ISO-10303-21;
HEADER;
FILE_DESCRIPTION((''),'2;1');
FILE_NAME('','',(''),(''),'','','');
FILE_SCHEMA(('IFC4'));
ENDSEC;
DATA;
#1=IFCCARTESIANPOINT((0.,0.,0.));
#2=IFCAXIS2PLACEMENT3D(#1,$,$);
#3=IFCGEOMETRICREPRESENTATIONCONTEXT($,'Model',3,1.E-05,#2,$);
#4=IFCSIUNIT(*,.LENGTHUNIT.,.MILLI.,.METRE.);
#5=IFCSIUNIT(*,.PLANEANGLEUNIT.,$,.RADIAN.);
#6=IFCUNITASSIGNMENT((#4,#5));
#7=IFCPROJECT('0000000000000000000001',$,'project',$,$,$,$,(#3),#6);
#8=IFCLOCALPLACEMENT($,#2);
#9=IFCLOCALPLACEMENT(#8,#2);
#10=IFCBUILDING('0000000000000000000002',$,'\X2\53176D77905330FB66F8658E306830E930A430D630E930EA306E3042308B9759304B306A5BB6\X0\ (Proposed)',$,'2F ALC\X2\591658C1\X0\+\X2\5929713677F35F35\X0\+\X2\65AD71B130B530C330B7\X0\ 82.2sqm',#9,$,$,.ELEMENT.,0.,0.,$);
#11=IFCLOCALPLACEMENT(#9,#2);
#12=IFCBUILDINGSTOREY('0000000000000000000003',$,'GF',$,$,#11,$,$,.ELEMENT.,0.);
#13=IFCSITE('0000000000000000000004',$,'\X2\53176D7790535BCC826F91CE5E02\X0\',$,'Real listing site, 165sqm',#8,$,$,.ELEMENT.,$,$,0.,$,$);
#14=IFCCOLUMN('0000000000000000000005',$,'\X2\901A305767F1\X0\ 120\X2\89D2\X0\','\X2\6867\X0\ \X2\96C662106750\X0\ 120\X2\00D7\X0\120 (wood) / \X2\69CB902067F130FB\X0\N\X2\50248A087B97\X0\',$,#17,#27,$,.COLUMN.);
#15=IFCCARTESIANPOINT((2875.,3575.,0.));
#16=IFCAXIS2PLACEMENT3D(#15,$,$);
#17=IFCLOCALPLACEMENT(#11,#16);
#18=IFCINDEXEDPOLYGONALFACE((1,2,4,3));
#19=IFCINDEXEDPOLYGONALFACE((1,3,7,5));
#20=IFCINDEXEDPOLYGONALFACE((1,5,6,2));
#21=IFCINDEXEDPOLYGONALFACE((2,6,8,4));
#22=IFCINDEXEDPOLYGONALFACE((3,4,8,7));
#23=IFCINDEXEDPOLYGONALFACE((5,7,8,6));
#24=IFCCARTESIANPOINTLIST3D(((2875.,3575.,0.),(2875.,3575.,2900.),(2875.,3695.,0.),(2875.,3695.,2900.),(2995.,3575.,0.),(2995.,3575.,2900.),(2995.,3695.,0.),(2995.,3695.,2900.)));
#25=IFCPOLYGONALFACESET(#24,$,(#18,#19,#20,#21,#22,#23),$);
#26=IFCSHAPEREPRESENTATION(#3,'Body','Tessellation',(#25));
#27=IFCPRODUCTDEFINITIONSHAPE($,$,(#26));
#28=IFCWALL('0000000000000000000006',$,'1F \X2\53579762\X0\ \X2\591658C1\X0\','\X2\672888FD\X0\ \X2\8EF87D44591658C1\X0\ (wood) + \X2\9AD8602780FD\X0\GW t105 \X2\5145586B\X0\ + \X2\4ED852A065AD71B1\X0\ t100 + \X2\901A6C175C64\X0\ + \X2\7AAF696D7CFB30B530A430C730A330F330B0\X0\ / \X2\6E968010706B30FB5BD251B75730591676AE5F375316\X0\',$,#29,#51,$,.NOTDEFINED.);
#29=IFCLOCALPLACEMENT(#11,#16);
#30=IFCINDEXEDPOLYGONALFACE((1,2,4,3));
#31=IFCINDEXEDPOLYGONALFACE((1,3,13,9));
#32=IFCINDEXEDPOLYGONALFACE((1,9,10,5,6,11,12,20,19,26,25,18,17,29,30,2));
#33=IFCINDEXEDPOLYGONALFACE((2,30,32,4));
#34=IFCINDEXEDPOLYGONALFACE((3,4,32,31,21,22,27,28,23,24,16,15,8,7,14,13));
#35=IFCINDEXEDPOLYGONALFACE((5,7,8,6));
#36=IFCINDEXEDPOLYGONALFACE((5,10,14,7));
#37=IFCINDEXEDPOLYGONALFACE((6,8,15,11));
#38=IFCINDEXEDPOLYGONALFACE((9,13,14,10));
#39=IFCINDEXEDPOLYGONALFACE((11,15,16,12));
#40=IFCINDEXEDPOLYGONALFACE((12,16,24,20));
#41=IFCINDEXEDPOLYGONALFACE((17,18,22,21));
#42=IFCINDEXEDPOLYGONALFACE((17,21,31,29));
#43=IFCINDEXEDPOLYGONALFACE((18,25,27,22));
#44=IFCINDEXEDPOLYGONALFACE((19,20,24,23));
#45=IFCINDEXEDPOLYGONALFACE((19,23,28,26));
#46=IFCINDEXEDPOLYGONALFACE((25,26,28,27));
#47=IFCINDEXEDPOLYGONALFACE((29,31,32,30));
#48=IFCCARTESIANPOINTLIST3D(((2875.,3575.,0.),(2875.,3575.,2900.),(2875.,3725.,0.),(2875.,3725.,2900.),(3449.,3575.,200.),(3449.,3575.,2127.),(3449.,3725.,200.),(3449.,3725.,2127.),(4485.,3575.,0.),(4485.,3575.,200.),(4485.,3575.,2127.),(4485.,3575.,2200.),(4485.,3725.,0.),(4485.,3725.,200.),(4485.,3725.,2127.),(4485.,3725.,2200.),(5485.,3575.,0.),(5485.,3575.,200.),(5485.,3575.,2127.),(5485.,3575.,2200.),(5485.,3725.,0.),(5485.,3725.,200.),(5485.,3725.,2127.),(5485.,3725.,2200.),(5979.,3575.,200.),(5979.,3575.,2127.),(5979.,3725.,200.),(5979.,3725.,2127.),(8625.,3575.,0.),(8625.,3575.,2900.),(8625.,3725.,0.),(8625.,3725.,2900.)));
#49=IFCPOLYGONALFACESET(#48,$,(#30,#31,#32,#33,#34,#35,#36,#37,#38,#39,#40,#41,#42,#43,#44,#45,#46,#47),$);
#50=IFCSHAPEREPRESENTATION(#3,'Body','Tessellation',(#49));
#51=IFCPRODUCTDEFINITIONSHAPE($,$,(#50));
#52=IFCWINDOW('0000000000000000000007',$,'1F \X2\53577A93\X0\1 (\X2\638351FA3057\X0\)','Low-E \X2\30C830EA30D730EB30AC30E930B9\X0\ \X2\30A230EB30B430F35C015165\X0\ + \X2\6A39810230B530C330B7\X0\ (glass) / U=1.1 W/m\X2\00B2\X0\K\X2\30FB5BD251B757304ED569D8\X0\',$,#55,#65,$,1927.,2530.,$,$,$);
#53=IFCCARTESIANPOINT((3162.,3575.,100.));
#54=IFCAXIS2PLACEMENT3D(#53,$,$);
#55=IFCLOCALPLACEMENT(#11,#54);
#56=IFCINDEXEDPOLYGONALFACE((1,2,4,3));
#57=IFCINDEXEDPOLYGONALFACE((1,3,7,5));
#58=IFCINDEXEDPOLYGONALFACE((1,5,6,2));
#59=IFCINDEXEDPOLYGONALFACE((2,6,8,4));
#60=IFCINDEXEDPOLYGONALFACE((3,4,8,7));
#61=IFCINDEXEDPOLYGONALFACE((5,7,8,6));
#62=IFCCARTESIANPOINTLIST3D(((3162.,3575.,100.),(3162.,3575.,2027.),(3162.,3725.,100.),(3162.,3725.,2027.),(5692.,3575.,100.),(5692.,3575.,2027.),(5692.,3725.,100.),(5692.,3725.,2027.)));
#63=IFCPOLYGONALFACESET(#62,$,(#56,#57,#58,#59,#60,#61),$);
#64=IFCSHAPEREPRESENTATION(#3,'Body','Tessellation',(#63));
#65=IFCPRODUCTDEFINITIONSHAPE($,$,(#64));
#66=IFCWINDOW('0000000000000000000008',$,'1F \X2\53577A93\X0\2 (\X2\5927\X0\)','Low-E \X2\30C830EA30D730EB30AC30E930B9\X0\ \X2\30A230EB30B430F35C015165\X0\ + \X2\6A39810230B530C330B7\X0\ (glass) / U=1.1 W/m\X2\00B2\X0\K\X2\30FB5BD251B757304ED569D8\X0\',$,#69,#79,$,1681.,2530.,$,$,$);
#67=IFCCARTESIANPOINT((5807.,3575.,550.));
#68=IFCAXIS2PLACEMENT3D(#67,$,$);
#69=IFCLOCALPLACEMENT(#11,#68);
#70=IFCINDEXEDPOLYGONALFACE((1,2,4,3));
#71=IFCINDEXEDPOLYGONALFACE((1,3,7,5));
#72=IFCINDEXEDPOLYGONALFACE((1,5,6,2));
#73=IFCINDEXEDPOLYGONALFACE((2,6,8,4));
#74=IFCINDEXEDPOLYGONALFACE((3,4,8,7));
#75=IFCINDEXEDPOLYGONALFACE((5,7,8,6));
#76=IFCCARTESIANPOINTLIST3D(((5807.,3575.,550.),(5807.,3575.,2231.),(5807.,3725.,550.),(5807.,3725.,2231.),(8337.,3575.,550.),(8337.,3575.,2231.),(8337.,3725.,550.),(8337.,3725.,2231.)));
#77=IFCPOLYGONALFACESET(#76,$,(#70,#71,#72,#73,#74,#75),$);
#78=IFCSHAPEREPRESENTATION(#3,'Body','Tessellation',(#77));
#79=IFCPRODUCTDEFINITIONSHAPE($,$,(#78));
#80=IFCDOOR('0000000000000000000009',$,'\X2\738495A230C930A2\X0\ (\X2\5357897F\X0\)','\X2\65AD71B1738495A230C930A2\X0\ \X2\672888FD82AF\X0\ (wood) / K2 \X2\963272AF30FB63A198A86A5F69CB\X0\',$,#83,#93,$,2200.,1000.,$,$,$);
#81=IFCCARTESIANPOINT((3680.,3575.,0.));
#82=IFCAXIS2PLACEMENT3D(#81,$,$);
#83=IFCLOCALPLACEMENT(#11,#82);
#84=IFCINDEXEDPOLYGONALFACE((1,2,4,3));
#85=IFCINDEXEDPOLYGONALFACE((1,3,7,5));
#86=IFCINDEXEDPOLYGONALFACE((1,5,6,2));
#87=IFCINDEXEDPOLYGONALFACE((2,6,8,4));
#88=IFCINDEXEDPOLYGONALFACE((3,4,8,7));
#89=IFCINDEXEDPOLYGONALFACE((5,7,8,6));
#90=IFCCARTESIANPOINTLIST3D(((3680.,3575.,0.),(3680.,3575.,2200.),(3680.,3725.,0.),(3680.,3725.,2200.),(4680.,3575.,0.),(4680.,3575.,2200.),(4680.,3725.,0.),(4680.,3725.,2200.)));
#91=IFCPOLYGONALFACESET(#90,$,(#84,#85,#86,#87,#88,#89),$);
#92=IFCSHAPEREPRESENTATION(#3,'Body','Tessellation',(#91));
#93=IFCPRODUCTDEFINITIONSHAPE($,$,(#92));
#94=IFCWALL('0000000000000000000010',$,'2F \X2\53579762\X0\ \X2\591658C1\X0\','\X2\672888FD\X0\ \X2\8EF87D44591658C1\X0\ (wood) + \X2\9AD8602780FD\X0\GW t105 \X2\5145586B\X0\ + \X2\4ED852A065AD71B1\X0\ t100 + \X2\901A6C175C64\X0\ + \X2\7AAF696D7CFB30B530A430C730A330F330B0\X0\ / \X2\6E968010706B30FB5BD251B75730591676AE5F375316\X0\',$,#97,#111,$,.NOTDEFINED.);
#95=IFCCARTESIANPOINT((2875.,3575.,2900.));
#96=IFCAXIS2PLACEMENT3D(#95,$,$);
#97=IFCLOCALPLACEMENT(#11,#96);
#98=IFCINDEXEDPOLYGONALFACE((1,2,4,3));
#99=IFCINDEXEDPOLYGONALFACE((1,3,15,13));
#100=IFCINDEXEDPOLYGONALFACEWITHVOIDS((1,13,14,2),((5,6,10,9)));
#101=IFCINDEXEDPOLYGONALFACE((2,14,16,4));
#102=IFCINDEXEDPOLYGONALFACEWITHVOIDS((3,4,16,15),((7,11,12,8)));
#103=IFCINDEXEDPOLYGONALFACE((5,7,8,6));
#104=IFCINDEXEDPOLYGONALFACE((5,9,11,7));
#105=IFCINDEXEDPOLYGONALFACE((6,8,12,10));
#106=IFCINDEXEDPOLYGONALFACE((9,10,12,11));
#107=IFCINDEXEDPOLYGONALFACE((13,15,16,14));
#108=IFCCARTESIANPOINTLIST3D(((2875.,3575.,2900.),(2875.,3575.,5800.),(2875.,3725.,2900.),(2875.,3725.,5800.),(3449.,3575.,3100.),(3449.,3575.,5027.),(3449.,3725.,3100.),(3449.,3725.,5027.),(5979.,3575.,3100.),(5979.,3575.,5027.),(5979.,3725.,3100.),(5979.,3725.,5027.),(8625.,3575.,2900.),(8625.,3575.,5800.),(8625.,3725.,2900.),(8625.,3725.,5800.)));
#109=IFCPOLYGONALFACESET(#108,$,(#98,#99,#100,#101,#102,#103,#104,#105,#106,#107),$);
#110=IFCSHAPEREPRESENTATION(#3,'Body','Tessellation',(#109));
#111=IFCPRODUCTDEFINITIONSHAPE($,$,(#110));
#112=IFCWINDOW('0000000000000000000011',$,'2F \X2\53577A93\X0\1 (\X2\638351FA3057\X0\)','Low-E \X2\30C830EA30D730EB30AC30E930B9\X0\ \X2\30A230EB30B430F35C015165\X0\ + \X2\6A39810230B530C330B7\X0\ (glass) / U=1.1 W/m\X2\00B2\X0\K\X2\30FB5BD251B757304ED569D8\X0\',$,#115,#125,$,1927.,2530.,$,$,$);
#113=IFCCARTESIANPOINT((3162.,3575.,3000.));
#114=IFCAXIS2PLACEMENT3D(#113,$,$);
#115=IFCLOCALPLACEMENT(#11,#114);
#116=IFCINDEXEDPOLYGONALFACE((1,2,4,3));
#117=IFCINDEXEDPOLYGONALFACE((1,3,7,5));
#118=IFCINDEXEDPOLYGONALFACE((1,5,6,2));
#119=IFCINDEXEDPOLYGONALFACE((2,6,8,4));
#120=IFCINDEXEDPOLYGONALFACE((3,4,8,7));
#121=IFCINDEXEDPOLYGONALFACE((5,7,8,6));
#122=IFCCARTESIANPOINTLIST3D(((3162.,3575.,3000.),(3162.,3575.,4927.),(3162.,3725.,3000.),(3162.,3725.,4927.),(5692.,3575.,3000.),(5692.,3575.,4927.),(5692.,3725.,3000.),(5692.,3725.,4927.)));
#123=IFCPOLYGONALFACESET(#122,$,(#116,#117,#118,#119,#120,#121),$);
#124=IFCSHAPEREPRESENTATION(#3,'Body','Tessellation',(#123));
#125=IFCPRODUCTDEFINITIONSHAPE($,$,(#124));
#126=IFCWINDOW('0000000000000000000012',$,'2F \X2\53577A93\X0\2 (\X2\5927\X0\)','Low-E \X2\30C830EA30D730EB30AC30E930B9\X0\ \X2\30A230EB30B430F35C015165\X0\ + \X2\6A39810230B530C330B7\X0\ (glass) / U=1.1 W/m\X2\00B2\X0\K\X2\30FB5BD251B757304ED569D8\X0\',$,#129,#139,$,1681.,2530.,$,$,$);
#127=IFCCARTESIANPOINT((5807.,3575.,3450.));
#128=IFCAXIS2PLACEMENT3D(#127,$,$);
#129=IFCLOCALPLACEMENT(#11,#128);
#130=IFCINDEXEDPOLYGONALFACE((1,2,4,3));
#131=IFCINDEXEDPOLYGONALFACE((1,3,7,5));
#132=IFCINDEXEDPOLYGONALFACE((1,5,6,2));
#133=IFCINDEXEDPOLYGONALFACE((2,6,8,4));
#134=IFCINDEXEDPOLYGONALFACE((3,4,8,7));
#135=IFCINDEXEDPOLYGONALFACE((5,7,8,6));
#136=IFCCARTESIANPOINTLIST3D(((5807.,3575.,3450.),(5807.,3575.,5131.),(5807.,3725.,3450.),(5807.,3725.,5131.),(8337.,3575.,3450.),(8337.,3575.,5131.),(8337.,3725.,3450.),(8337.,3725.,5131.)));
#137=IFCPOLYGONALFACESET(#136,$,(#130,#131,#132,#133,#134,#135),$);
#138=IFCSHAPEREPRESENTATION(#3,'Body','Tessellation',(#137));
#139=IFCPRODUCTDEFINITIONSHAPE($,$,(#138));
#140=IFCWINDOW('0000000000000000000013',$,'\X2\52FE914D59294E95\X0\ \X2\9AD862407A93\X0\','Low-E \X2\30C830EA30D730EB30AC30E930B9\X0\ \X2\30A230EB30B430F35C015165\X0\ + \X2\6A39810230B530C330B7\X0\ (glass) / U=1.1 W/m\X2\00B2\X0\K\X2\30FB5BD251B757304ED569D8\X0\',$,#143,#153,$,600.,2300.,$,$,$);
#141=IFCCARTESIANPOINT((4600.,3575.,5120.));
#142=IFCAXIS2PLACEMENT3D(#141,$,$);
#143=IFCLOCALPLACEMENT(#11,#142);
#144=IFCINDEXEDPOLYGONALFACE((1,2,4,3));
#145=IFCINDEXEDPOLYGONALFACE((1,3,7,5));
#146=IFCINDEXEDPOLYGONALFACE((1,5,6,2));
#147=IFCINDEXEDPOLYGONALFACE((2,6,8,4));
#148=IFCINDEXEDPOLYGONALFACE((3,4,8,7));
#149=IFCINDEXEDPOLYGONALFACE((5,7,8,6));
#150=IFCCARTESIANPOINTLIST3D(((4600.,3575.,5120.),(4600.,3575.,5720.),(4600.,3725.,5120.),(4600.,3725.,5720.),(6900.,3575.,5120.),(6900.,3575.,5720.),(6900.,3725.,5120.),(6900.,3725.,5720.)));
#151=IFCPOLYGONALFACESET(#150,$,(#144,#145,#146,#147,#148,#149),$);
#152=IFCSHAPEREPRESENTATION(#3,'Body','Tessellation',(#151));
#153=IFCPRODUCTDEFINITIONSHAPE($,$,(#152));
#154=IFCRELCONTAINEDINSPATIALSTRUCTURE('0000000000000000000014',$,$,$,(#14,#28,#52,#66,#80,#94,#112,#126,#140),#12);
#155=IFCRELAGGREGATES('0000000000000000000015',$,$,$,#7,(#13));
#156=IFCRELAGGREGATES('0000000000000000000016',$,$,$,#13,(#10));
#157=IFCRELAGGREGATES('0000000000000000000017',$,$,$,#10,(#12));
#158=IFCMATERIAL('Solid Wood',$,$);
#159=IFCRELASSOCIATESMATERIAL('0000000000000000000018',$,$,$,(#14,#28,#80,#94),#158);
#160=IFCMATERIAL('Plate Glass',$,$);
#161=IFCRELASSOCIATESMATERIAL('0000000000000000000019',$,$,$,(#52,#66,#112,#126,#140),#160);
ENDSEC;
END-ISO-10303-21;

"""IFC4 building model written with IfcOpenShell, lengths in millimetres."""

from ifc_helpers import new_model, si_unit, frame, frame_2d, origin, place, context, project, spatial, rectangle, extrude, material, element, fill, save


model = new_model("IFC4")

# Units and contexts
model_context = context("Model", 3, precision=1e-05, world=origin())
ifc_project = project(units=[si_unit("LENGTHUNIT", "METRE", prefix="MILLI"), si_unit("PLANEANGLEUNIT", "RADIAN")], contexts=[model_context])

# Site, building, storey
site_placement = place(None, origin())
site = spatial("IfcSite", under=ifc_project, at=site_placement, Name="北海道富良野市", ObjectType="Real listing site, 165sqm", CompositionType="ELEMENT", RefElevation=0.0)
building_placement = place(site_placement, origin())
building = spatial("IfcBuilding", under=site, at=building_placement, Name="北海道・書斎とライブラリのある静かな家 (Proposed)", ObjectType="2F ALC外壁+天然石張+断熱サッシ 82.2sqm", CompositionType="ELEMENT", ElevationOfRefHeight=0.0, ElevationOfTerrain=0.0)
storey_placement = place(building_placement, origin())
storey = spatial("IfcBuildingStorey", under=building, at=storey_placement, Name="GF", CompositionType="ELEMENT", Elevation=0.0)

# Column
ifc_material_1 = material(Name="Solid Wood")
column_placement = place(storey_placement, frame((2875.0, 3575.0, 0.0)))
element("IfcColumn", 1, at=column_placement, inside=storey, material=ifc_material_1, Name="通し柱 120角", Description="桧 集成材 120×120 (wood) / 構造柱・N値計算", PredefinedType="COLUMN", context=model_context, shape_type="SweptSolid", body=[
    extrude(rectangle(XDim=120.0, YDim=120.0, at=frame_2d((60.0, 60.0))), frame((2875.0, 3575.0, 0.0)), (0.0, 0.0, 1.0), 2900.0),
])

# Wall, openings, windows, door
wall_1_placement = place(storey_placement, frame((2875.0, 3575.0, 0.0)))
wall_1 = element("IfcWall", 2, at=wall_1_placement, inside=storey, material=ifc_material_1, Name="1F 南面 外壁", Description="木製 軸組外壁 (wood) + 高性能GW t105 充填 + 付加断熱 t100 + 通気層 + 窯業系サイディング / 準耐火・寒冷地外皮強化", PredefinedType="NOTDEFINED", context=model_context, shape_type="SweptSolid", body=[
    extrude(rectangle(XDim=5750.0, YDim=150.0, at=frame_2d((2875.0, 75.0))), frame((2875.0, 3575.0, 0.0)), (0.0, 0.0, 1.0), 2900.0),
])
opening_1_placement = place(storey_placement, frame((3162.0, 3575.0, 100.0)))
opening_1 = element("IfcOpeningElement", 3, at=opening_1_placement, cuts=wall_1, PredefinedType="NOTDEFINED", context=model_context, shape_type="SweptSolid", body=[
    extrude(rectangle(XDim=2530.0, YDim=150.0, at=frame_2d((1265.0, 75.0))), frame((3162.0, 3575.0, 100.0)), (0.0, 0.0, 1.0), 1927.0),
])
opening_2_placement = place(storey_placement, frame((5807.0, 3575.0, 550.0)))
opening_2 = element("IfcOpeningElement", 4, at=opening_2_placement, cuts=wall_1, PredefinedType="NOTDEFINED", context=model_context, shape_type="SweptSolid", body=[
    extrude(rectangle(XDim=2530.0, YDim=150.0, at=frame_2d((1265.0, 75.0))), frame((5807.0, 3575.0, 550.0)), (0.0, 0.0, 1.0), 1681.0),
])
opening_3_placement = place(storey_placement, frame((3680.0, 3575.0, 0.0)))
opening_3 = element("IfcOpeningElement", 5, at=opening_3_placement, cuts=wall_1, PredefinedType="NOTDEFINED", context=model_context, shape_type="SweptSolid", body=[
    extrude(rectangle(XDim=1000.0, YDim=150.0, at=frame_2d((500.0, 75.0))), frame((3680.0, 3575.0, 0.0)), (0.0, 0.0, 1.0), 2200.0),
])
ifc_material_2 = material(Name="Plate Glass")
window_1_placement = place(storey_placement, frame((3162.0, 3575.0, 100.0)))
window_1 = element("IfcWindow", 6, at=window_1_placement, inside=storey, material=ifc_material_2, Name="1F 南窓1 (掃出し)", Description="Low-E トリプルガラス アルゴン封入 + 樹脂サッシ (glass) / U=1.1 W/m²K・寒冷地仕様", OverallHeight=1927.0, OverallWidth=2530.0, context=model_context, shape_type="SweptSolid", body=[
    extrude(rectangle(XDim=2530.0, YDim=150.0, at=frame_2d((1265.0, 75.0))), frame((3162.0, 3575.0, 100.0)), (0.0, 0.0, 1.0), 1927.0),
])
fill(opening_1, window_1)
window_2_placement = place(storey_placement, frame((5807.0, 3575.0, 550.0)))
window_2 = element("IfcWindow", 7, at=window_2_placement, inside=storey, material=ifc_material_2, Name="1F 南窓2 (大)", Description="Low-E トリプルガラス アルゴン封入 + 樹脂サッシ (glass) / U=1.1 W/m²K・寒冷地仕様", OverallHeight=1681.0, OverallWidth=2530.0, context=model_context, shape_type="SweptSolid", body=[
    extrude(rectangle(XDim=2530.0, YDim=150.0, at=frame_2d((1265.0, 75.0))), frame((5807.0, 3575.0, 550.0)), (0.0, 0.0, 1.0), 1681.0),
])
fill(opening_2, window_2)
door_placement = place(storey_placement, frame((3680.0, 3575.0, 0.0)))
door = element("IfcDoor", 8, at=door_placement, inside=storey, material=ifc_material_1, Name="玄関ドア (南西)", Description="断熱玄関ドア 木製芯 (wood) / K2 防犯・採風機構", OverallHeight=2200.0, OverallWidth=1000.0, context=model_context, shape_type="SweptSolid", body=[
    extrude(rectangle(XDim=1000.0, YDim=150.0, at=frame_2d((500.0, 75.0))), frame((3680.0, 3575.0, 0.0)), (0.0, 0.0, 1.0), 2200.0),
])
fill(opening_3, door)

# Wall, openings, windows
wall_2_placement = place(storey_placement, frame((2875.0, 3575.0, 2900.0)))
wall_2 = element("IfcWall", 9, at=wall_2_placement, inside=storey, material=ifc_material_1, Name="2F 南面 外壁", Description="木製 軸組外壁 (wood) + 高性能GW t105 充填 + 付加断熱 t100 + 通気層 + 窯業系サイディング / 準耐火・寒冷地外皮強化", PredefinedType="NOTDEFINED", context=model_context, shape_type="SweptSolid", body=[
    extrude(rectangle(XDim=5750.0, YDim=150.0, at=frame_2d((2875.0, 75.0))), frame((2875.0, 3575.0, 2900.0)), (0.0, 0.0, 1.0), 2900.0),
])
opening_4_placement = place(storey_placement, frame((3162.0, 3575.0, 3000.0)))
opening_4 = element("IfcOpeningElement", 10, at=opening_4_placement, cuts=wall_2, PredefinedType="NOTDEFINED", context=model_context, shape_type="SweptSolid", body=[
    extrude(rectangle(XDim=2530.0, YDim=150.0, at=frame_2d((1265.0, 75.0))), frame((3162.0, 3575.0, 3000.0)), (0.0, 0.0, 1.0), 1927.0),
])
opening_5_placement = place(storey_placement, frame((5807.0, 3575.0, 3450.0)))
opening_5 = element("IfcOpeningElement", 11, at=opening_5_placement, cuts=wall_2, PredefinedType="NOTDEFINED", context=model_context, shape_type="SweptSolid", body=[
    extrude(rectangle(XDim=2530.0, YDim=150.0, at=frame_2d((1265.0, 75.0))), frame((5807.0, 3575.0, 3450.0)), (0.0, 0.0, 1.0), 1681.0),
])
opening_6_placement = place(storey_placement, frame((4600.0, 3575.0, 5120.0)))
opening_6 = element("IfcOpeningElement", 12, at=opening_6_placement, cuts=wall_2, PredefinedType="NOTDEFINED", context=model_context, shape_type="SweptSolid", body=[
    extrude(rectangle(XDim=2300.0, YDim=150.0, at=frame_2d((1150.0, 75.0))), frame((4600.0, 3575.0, 5120.0)), (0.0, 0.0, 1.0), 600.0),
])
window_3_placement = place(storey_placement, frame((3162.0, 3575.0, 3000.0)))
window_3 = element("IfcWindow", 13, at=window_3_placement, inside=storey, material=ifc_material_2, Name="2F 南窓1 (掃出し)", Description="Low-E トリプルガラス アルゴン封入 + 樹脂サッシ (glass) / U=1.1 W/m²K・寒冷地仕様", OverallHeight=1927.0, OverallWidth=2530.0, context=model_context, shape_type="SweptSolid", body=[
    extrude(rectangle(XDim=2530.0, YDim=150.0, at=frame_2d((1265.0, 75.0))), frame((3162.0, 3575.0, 3000.0)), (0.0, 0.0, 1.0), 1927.0),
])
fill(opening_4, window_3)
window_4_placement = place(storey_placement, frame((5807.0, 3575.0, 3450.0)))
window_4 = element("IfcWindow", 14, at=window_4_placement, inside=storey, material=ifc_material_2, Name="2F 南窓2 (大)", Description="Low-E トリプルガラス アルゴン封入 + 樹脂サッシ (glass) / U=1.1 W/m²K・寒冷地仕様", OverallHeight=1681.0, OverallWidth=2530.0, context=model_context, shape_type="SweptSolid", body=[
    extrude(rectangle(XDim=2530.0, YDim=150.0, at=frame_2d((1265.0, 75.0))), frame((5807.0, 3575.0, 3450.0)), (0.0, 0.0, 1.0), 1681.0),
])
fill(opening_5, window_4)
window_5_placement = place(storey_placement, frame((4600.0, 3575.0, 5120.0)))
window_5 = element("IfcWindow", 15, at=window_5_placement, inside=storey, material=ifc_material_2, Name="勾配天井 高所窓", Description="Low-E トリプルガラス アルゴン封入 + 樹脂サッシ (glass) / U=1.1 W/m²K・寒冷地仕様", OverallHeight=600.0, OverallWidth=2300.0, context=model_context, shape_type="SweptSolid", body=[
    extrude(rectangle(XDim=2300.0, YDim=150.0, at=frame_2d((1150.0, 75.0))), frame((4600.0, 3575.0, 5120.0)), (0.0, 0.0, 1.0), 600.0),
])
fill(opening_6, window_5)

save(model, "model.ifc")
